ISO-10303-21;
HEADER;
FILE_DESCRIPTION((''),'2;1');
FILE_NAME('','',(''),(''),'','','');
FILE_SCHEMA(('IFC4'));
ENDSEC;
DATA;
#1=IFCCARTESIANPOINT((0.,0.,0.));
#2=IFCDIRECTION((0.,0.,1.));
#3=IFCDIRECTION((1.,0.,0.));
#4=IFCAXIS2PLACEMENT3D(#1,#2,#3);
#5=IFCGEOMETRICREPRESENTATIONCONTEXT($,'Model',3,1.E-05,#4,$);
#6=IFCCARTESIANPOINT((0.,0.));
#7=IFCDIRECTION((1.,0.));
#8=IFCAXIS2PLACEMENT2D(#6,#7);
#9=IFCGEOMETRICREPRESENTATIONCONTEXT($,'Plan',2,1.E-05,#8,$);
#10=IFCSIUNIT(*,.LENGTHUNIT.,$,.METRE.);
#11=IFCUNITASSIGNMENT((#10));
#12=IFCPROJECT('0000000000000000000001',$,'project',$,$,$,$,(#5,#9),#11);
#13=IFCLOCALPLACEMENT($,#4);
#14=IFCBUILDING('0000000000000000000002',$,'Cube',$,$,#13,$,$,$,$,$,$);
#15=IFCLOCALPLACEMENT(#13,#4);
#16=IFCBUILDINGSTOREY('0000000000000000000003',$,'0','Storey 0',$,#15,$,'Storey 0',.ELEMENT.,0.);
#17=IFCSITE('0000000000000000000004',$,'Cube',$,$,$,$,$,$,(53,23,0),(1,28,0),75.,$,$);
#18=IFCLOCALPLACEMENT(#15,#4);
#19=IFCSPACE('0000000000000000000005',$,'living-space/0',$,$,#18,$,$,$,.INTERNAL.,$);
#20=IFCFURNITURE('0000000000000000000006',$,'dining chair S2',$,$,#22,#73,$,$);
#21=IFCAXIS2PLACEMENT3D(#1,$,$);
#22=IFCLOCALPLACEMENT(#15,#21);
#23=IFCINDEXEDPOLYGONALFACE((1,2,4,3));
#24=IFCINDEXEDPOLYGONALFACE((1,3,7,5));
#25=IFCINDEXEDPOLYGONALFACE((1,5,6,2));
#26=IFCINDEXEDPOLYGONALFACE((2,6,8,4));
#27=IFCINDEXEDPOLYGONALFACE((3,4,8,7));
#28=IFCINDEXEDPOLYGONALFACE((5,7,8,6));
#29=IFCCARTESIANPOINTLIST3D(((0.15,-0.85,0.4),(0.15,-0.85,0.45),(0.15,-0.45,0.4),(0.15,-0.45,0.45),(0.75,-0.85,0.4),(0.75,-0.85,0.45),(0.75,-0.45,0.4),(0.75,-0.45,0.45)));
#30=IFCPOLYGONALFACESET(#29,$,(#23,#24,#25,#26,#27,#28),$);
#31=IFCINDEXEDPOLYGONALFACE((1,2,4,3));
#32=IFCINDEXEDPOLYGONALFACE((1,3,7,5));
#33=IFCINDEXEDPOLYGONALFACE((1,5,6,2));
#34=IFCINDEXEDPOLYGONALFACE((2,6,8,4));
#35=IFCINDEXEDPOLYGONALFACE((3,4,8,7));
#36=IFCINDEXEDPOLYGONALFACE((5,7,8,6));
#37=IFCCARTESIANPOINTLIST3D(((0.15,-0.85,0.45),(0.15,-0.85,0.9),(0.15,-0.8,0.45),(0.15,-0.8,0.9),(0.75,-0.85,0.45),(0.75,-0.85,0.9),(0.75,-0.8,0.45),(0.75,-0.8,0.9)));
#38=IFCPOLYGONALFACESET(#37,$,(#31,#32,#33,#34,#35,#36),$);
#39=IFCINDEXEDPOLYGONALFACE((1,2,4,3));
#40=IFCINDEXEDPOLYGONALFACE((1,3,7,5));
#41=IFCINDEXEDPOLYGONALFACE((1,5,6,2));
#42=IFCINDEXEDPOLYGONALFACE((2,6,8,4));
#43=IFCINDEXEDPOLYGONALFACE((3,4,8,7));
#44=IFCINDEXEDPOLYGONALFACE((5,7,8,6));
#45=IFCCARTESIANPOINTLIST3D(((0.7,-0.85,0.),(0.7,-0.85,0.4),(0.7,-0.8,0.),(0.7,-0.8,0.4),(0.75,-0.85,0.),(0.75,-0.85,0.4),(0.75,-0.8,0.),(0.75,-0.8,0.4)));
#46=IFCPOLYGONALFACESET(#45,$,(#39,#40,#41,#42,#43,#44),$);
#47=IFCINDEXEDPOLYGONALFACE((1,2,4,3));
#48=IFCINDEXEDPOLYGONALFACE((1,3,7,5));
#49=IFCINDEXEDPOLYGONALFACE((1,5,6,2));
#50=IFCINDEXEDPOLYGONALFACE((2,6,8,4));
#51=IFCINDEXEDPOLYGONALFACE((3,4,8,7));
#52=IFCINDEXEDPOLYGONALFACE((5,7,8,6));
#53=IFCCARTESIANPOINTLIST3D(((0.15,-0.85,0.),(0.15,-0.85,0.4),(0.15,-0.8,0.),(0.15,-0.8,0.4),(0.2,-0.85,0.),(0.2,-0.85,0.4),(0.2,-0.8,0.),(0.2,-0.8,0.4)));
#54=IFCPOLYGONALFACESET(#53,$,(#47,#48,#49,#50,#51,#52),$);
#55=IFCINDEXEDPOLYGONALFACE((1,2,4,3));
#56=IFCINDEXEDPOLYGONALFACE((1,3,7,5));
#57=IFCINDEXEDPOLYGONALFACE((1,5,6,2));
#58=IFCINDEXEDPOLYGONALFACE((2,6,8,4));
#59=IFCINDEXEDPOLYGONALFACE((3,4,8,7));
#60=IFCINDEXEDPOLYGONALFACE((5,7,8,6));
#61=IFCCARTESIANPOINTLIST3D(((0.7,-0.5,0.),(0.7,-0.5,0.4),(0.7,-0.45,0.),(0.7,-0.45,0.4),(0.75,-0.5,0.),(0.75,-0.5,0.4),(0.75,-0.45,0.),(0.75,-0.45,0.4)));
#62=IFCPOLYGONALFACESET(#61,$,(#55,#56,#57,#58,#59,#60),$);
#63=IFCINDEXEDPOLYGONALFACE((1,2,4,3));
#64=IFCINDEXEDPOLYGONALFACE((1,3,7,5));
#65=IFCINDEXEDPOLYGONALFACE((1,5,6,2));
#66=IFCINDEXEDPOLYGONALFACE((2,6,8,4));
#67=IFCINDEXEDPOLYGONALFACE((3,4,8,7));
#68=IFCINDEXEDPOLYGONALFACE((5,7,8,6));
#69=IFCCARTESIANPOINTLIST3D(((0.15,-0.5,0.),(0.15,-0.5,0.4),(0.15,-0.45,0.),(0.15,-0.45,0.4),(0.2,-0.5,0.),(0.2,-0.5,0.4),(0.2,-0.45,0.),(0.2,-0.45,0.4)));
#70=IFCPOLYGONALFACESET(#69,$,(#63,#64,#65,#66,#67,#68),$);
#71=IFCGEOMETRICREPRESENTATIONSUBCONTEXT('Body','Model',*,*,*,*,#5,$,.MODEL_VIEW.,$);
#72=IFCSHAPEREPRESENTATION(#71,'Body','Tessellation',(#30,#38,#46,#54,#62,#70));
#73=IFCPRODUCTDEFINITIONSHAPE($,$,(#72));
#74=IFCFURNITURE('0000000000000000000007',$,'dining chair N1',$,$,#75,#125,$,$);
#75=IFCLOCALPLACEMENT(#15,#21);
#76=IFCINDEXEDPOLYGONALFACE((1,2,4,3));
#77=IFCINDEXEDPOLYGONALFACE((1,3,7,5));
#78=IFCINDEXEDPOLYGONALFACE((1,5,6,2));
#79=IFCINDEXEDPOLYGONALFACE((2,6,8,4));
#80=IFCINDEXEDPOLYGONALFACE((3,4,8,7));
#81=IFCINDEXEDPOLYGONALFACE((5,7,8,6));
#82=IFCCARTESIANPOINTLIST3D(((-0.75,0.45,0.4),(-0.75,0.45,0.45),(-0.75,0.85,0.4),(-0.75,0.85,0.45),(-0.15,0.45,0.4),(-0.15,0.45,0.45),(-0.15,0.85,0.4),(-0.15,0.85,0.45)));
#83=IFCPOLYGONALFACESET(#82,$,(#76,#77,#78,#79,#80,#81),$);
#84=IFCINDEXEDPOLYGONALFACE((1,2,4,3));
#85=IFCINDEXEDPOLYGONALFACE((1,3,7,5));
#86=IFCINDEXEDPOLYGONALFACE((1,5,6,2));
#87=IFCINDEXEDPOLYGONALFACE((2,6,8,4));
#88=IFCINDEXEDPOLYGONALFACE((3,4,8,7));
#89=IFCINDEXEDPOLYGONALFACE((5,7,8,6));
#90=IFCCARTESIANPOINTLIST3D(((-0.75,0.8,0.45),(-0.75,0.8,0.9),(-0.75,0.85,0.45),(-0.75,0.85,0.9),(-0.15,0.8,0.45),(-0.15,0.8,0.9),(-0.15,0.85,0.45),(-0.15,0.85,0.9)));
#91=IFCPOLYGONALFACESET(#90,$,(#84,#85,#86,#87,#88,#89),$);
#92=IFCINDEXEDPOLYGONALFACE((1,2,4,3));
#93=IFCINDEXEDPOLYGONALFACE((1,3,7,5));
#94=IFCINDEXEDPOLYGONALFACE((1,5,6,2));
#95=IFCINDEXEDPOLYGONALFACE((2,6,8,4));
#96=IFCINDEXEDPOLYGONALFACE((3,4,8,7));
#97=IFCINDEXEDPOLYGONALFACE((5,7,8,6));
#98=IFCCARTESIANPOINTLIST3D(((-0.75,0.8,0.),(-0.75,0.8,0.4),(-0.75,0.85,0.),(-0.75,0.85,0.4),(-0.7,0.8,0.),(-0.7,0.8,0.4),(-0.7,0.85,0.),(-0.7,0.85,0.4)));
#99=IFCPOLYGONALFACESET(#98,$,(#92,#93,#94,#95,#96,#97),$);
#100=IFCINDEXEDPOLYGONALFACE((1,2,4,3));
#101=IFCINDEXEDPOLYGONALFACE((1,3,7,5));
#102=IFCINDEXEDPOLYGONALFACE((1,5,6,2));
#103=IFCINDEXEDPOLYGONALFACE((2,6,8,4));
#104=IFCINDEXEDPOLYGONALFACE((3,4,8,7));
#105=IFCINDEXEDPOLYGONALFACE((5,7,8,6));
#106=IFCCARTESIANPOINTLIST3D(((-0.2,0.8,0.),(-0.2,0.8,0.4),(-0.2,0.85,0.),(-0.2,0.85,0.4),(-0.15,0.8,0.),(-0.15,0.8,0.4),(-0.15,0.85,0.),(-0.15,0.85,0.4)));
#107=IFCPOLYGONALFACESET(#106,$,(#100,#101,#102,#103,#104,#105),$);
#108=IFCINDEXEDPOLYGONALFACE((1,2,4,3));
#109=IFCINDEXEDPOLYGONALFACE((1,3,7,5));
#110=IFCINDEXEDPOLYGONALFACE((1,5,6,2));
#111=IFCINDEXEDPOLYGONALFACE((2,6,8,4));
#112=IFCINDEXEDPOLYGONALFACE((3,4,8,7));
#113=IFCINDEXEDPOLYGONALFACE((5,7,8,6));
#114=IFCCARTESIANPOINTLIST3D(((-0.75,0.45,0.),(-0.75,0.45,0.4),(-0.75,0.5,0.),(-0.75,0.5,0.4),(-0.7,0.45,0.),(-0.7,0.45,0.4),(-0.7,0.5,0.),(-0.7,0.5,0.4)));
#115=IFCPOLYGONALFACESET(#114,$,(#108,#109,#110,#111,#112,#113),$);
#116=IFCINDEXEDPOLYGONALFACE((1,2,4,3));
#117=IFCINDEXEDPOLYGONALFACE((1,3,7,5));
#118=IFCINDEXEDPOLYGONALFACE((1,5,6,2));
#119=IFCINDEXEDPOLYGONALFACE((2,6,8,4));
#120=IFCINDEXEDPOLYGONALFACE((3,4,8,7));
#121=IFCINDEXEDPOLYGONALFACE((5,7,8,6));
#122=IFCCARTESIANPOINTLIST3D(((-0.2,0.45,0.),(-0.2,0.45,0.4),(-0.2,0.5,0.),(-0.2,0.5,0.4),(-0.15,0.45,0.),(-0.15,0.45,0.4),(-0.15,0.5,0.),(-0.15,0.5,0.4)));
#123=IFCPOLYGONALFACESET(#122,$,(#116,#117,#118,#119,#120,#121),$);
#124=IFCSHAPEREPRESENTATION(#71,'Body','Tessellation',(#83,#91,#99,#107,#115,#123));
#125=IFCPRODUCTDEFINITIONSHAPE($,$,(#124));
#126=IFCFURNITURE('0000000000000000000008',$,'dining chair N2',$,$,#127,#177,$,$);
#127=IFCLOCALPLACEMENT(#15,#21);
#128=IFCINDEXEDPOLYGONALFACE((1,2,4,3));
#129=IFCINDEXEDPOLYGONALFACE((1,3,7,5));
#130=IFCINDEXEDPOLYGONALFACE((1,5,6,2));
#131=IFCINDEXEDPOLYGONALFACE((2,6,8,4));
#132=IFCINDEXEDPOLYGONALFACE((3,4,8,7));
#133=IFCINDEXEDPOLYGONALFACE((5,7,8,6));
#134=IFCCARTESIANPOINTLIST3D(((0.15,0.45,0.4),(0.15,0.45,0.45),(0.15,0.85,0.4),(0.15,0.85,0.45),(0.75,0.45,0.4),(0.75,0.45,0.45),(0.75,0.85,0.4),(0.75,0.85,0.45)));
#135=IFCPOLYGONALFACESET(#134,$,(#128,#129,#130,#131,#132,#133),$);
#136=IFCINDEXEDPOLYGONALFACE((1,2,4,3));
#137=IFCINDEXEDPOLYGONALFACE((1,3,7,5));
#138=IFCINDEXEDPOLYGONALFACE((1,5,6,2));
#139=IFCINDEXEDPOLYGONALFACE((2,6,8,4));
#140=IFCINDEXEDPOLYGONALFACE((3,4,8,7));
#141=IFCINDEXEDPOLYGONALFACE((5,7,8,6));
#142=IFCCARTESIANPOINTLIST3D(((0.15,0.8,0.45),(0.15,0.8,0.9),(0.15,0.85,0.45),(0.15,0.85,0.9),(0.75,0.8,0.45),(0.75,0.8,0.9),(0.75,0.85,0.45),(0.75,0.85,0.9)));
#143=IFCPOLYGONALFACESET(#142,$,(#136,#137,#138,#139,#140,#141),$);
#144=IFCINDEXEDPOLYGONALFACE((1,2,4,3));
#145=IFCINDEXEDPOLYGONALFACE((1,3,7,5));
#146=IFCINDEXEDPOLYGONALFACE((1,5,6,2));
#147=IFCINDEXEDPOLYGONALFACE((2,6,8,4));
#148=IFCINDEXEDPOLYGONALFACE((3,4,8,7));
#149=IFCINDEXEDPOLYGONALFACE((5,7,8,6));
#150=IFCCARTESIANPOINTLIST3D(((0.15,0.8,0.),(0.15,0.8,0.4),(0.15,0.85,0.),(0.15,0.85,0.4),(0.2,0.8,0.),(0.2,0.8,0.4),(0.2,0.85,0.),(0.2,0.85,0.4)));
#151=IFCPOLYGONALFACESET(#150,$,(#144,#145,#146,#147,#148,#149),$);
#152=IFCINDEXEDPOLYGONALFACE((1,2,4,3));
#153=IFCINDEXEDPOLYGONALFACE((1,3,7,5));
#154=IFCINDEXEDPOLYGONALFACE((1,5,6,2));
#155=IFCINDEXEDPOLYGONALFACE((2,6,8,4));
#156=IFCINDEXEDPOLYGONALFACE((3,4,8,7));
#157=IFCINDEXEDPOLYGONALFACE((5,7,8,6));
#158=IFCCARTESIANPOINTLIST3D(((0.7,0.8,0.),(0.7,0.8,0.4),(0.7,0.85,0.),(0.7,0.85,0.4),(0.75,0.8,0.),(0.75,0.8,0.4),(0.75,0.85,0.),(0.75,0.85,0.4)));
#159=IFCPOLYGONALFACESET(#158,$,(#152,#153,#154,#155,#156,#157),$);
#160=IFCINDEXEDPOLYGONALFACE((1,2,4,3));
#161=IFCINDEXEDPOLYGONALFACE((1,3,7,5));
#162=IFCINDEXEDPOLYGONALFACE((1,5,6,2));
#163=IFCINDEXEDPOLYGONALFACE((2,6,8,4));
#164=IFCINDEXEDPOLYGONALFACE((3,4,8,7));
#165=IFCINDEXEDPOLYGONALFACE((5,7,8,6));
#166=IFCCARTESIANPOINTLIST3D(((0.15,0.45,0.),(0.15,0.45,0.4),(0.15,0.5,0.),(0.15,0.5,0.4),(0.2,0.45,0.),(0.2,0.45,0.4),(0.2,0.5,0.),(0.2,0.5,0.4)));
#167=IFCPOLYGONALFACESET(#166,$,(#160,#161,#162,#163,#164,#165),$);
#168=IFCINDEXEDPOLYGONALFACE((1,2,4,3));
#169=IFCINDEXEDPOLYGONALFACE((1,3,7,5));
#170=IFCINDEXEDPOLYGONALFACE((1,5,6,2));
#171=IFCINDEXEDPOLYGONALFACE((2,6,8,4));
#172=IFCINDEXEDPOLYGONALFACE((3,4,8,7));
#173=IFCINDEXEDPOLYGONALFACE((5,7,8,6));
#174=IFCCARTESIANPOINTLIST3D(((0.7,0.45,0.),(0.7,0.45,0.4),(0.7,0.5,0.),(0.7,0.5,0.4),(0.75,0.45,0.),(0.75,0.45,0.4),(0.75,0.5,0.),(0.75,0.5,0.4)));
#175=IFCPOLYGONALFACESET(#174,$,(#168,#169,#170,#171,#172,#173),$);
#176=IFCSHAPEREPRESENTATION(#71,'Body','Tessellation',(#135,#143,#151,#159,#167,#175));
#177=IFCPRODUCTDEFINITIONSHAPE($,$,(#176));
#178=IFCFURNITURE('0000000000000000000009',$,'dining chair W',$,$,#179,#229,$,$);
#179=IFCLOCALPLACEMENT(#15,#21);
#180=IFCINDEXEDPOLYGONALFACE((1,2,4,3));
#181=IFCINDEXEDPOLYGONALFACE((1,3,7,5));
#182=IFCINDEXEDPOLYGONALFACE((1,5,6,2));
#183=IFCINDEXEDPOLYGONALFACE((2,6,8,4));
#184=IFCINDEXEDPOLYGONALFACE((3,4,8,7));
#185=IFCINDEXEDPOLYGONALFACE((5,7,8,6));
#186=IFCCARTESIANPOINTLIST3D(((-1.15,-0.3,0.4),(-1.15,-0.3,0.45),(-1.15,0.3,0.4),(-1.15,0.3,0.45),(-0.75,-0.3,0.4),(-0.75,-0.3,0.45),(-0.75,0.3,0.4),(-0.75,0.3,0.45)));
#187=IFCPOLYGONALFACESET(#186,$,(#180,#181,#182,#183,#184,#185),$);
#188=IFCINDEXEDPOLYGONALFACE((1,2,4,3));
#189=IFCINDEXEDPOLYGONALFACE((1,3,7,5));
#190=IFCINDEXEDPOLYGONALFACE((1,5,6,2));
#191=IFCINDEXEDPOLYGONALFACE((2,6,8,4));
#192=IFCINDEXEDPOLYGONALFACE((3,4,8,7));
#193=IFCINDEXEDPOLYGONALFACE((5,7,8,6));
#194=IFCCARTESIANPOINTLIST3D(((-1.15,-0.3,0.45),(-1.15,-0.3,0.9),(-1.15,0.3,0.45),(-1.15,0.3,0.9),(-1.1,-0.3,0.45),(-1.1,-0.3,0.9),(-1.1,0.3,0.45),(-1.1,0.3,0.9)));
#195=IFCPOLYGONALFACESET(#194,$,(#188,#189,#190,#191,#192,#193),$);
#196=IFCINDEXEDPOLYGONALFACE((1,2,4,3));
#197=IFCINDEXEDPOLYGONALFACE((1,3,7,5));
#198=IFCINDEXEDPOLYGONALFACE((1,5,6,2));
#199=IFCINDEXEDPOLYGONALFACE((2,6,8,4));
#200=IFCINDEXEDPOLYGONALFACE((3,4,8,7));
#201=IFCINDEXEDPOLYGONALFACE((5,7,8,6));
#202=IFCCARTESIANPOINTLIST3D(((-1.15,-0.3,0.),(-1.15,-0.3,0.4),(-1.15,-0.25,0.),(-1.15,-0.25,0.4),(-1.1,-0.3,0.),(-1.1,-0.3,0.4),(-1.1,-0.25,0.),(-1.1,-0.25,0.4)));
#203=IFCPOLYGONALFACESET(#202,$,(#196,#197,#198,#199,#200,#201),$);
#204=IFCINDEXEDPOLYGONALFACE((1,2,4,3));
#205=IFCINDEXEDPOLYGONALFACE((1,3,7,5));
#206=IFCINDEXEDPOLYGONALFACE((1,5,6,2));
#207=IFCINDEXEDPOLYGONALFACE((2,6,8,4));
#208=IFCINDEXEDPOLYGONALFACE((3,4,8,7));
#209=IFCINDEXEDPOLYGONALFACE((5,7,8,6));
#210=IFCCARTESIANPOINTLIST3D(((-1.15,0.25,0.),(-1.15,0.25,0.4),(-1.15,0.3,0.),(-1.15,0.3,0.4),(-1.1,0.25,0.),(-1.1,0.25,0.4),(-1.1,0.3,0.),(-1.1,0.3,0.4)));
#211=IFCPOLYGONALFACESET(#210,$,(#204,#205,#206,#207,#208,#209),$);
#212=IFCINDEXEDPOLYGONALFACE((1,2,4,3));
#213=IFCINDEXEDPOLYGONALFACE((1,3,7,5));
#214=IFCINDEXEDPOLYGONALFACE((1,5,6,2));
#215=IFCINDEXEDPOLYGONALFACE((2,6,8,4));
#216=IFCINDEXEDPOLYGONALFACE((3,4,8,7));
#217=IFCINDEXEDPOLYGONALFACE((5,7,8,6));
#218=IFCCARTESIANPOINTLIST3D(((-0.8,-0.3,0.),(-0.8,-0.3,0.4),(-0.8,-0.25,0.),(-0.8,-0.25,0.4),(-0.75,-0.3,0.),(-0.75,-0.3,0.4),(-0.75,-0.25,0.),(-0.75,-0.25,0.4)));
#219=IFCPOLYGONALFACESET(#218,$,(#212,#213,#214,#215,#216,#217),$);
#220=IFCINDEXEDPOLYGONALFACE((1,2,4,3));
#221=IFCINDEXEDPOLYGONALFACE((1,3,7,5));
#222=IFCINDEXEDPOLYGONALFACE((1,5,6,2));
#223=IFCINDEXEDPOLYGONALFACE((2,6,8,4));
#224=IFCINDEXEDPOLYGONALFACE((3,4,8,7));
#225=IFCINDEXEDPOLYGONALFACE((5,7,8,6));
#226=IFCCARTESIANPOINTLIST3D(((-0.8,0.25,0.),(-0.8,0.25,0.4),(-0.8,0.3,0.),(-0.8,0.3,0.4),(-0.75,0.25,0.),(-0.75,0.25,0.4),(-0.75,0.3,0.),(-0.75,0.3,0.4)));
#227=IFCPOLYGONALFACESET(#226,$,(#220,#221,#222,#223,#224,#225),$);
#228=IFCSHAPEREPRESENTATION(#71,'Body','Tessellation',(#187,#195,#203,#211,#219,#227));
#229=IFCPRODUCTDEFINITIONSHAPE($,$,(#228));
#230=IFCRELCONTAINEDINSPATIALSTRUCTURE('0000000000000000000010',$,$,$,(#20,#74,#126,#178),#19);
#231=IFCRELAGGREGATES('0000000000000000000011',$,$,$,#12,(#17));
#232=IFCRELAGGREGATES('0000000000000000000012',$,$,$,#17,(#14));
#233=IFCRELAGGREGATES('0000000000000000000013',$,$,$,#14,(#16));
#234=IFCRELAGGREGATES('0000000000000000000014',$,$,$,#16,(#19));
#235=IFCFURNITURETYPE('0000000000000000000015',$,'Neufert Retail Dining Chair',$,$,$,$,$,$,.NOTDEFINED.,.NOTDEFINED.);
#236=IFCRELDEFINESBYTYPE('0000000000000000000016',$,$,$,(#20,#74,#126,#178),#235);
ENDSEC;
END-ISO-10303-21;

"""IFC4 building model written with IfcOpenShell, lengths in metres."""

from ifc_helpers import new_model, entity, si_unit, frame, origin_with_axes, origin_2d_with_axis, place, context, subcontext, project, spatial, line, indexed_curve, outline, extrude, shape, source, transform, mapped, type_object, type_shapes, element, save


model = new_model("IFC4")

# Units and contexts
model_context = context("Model", 3, precision=1e-05, world=origin_with_axes())
plan_context = context("Plan", 2, precision=1e-05, world=origin_2d_with_axis())
body_context_1 = subcontext(model_context, "Body", "Model", "MODEL_VIEW")
body_context_2 = subcontext(plan_context, "Body", "Plan", "PLAN_VIEW")
ifc_project = project(units=[si_unit("LENGTHUNIT", "METRE")], contexts=[model_context, plan_context])

# Site, building, storey
site = spatial("IfcSite", under=ifc_project, Name="Cube", RefLatitude=(53, 23, 0), RefLongitude=(1, 28, 0), RefElevation=75.0)
building_placement = place(None, origin_with_axes())
building = spatial("IfcBuilding", under=site, at=building_placement, Name="Cube")
storey_placement = place(building_placement, origin_with_axes())
storey = spatial("IfcBuildingStorey", under=building, at=storey_placement, Name="0", Description="Storey 0", LongName="Storey 0", CompositionType="ELEMENT", Elevation=0.0)

# Shared definitions
space_placement = place(storey_placement, origin_with_axes())
space = spatial("IfcSpace", under=storey, at=space_placement, Name="living-space/0", PredefinedType="INTERNAL")

# Furniture
furniture_type_1 = type_object("IfcFurnitureType", Name="Neufert Retail Dining Chair", AssemblyPlace="NOTDEFINED", PredefinedType="NOTDEFINED")
shared_shape_1 = source(origin_with_axes(), body_context_1, "Body", "SweptSolid", [
    extrude(outline(indexed_curve([(-0.3, 0.0), (0.3, 0.0), (0.3, -0.4), (-0.3, -0.4)], segments=[line(1, 2, 3, 4, 1)])), frame((0.0, 0.0, 0.45), z_axis=(0.0, 0.0, 1.0), x_axis=(1.0, 0.0, 0.0)), (0.0, 0.0, -1.0), 0.05),
    extrude(outline(indexed_curve([(-0.3, 0.0), (0.3, 0.0), (0.3, -0.05), (-0.3, -0.05)], segments=[line(1, 2, 3, 4, 1)])), frame((0.0, 0.0, 0.9), z_axis=(0.0, 0.0, 1.0), x_axis=(1.0, 0.0, 0.0)), (0.0, 0.0, -1.0), 0.45),
    extrude(outline(indexed_curve([(-0.3, 0.0), (-0.25, 0.0), (-0.25, -0.05), (-0.3, -0.05)], segments=[line(1, 2, 3, 4, 1)])), origin_with_axes(), (0.0, 0.0, 1.0), 0.4),
    extrude(outline(indexed_curve([(0.3, 0.0), (0.25, 0.0), (0.25, -0.05), (0.3, -0.05)], segments=[line(1, 2, 3, 4, 1)])), origin_with_axes(), (0.0, 0.0, 1.0), 0.4),
    extrude(outline(indexed_curve([(-0.3, -0.4), (-0.25, -0.4), (-0.25, -0.35), (-0.3, -0.35)], segments=[line(1, 2, 3, 4, 1)])), origin_with_axes(), (0.0, 0.0, 1.0), 0.4),
    extrude(outline(indexed_curve([(0.3, -0.4), (0.25, -0.4), (0.25, -0.35), (0.3, -0.35)], segments=[line(1, 2, 3, 4, 1)])), origin_with_axes(), (0.0, 0.0, 1.0), 0.4),
])
shared_shape_2 = source(origin_with_axes(), body_context_2, "Body", "Curve2D", [
    entity("IfcIndexedPolyCurve", entity("IfcCartesianPointList2D", [[-0.3, -0.4], [0.3, -0.4]])),
    entity("IfcIndexedPolyCurve", entity("IfcCartesianPointList2D", [[-0.3, -0.4], [-0.3, -0.3], [-0.2121, -0.0879], [0.0, 0.0], [0.2121, -0.0879], [0.3, -0.3], [0.3, -0.4]]), [entity("IfcLineIndex", [1, 2]), entity("IfcArcIndex", [2, 3, 4]), entity("IfcArcIndex", [4, 5, 6]), entity("IfcLineIndex", [6, 7])]),
    entity("IfcIndexedPolyCurve", entity("IfcCartesianPointList2D", [[-0.26, -0.4], [-0.26, -0.3], [-0.1838, -0.1162], [0.0, -0.04], [0.1838, -0.1162], [0.26, -0.3], [0.26, -0.4]]), [entity("IfcLineIndex", [1, 2]), entity("IfcArcIndex", [2, 3, 4]), entity("IfcArcIndex", [4, 5, 6]), entity("IfcLineIndex", [6, 7])]),
])
type_shapes(furniture_type_1, [shared_shape_1, shared_shape_2])
for number, where, z_axis, x_axis, name in (
    (1, (0.45, -0.85, 0.0), (0.0, 0.0, 1.0), (-1.0, 0.0, 0.0), "dining chair S2"),
    (2, (-0.45, 0.85, 0.0), (0.0, 0.0, 1.0), (1.0, 0.0, 0.0), "dining chair N1"),
    (3, (0.45, 0.85, 0.0), (0.0, 0.0, 1.0), (1.0, 0.0, 0.0), "dining chair N2"),
    (4, (-1.15, 0.0, 0.0), (0.0, 0.0, 1.0), (0.0, 1.0, 0.0), "dining chair W"),
):
    element("IfcFurniture", number, at=place(space_placement, frame(where, z_axis=z_axis, x_axis=x_axis)), inside=space, type_object=furniture_type_1, Name=name, shapes=[
        shape(body_context_1, "Body", "MappedRepresentation", [mapped(shared_shape_1, transform((0.0, 0.0, 0.0), x_axis=(1.0, 0.0, 0.0), y_axis=(0.0, 1.0, 0.0), z_axis=(0.0, 0.0, 1.0), scale=1.0))]),
        shape(body_context_2, "Body", "MappedRepresentation", [mapped(shared_shape_2, transform((0.0, 0.0, 0.0), x_axis=(1.0, 0.0, 0.0), y_axis=(0.0, 1.0, 0.0), z_axis=(0.0, 0.0, 1.0), scale=1.0))]),
    ])

save(model, "model.ifc")
